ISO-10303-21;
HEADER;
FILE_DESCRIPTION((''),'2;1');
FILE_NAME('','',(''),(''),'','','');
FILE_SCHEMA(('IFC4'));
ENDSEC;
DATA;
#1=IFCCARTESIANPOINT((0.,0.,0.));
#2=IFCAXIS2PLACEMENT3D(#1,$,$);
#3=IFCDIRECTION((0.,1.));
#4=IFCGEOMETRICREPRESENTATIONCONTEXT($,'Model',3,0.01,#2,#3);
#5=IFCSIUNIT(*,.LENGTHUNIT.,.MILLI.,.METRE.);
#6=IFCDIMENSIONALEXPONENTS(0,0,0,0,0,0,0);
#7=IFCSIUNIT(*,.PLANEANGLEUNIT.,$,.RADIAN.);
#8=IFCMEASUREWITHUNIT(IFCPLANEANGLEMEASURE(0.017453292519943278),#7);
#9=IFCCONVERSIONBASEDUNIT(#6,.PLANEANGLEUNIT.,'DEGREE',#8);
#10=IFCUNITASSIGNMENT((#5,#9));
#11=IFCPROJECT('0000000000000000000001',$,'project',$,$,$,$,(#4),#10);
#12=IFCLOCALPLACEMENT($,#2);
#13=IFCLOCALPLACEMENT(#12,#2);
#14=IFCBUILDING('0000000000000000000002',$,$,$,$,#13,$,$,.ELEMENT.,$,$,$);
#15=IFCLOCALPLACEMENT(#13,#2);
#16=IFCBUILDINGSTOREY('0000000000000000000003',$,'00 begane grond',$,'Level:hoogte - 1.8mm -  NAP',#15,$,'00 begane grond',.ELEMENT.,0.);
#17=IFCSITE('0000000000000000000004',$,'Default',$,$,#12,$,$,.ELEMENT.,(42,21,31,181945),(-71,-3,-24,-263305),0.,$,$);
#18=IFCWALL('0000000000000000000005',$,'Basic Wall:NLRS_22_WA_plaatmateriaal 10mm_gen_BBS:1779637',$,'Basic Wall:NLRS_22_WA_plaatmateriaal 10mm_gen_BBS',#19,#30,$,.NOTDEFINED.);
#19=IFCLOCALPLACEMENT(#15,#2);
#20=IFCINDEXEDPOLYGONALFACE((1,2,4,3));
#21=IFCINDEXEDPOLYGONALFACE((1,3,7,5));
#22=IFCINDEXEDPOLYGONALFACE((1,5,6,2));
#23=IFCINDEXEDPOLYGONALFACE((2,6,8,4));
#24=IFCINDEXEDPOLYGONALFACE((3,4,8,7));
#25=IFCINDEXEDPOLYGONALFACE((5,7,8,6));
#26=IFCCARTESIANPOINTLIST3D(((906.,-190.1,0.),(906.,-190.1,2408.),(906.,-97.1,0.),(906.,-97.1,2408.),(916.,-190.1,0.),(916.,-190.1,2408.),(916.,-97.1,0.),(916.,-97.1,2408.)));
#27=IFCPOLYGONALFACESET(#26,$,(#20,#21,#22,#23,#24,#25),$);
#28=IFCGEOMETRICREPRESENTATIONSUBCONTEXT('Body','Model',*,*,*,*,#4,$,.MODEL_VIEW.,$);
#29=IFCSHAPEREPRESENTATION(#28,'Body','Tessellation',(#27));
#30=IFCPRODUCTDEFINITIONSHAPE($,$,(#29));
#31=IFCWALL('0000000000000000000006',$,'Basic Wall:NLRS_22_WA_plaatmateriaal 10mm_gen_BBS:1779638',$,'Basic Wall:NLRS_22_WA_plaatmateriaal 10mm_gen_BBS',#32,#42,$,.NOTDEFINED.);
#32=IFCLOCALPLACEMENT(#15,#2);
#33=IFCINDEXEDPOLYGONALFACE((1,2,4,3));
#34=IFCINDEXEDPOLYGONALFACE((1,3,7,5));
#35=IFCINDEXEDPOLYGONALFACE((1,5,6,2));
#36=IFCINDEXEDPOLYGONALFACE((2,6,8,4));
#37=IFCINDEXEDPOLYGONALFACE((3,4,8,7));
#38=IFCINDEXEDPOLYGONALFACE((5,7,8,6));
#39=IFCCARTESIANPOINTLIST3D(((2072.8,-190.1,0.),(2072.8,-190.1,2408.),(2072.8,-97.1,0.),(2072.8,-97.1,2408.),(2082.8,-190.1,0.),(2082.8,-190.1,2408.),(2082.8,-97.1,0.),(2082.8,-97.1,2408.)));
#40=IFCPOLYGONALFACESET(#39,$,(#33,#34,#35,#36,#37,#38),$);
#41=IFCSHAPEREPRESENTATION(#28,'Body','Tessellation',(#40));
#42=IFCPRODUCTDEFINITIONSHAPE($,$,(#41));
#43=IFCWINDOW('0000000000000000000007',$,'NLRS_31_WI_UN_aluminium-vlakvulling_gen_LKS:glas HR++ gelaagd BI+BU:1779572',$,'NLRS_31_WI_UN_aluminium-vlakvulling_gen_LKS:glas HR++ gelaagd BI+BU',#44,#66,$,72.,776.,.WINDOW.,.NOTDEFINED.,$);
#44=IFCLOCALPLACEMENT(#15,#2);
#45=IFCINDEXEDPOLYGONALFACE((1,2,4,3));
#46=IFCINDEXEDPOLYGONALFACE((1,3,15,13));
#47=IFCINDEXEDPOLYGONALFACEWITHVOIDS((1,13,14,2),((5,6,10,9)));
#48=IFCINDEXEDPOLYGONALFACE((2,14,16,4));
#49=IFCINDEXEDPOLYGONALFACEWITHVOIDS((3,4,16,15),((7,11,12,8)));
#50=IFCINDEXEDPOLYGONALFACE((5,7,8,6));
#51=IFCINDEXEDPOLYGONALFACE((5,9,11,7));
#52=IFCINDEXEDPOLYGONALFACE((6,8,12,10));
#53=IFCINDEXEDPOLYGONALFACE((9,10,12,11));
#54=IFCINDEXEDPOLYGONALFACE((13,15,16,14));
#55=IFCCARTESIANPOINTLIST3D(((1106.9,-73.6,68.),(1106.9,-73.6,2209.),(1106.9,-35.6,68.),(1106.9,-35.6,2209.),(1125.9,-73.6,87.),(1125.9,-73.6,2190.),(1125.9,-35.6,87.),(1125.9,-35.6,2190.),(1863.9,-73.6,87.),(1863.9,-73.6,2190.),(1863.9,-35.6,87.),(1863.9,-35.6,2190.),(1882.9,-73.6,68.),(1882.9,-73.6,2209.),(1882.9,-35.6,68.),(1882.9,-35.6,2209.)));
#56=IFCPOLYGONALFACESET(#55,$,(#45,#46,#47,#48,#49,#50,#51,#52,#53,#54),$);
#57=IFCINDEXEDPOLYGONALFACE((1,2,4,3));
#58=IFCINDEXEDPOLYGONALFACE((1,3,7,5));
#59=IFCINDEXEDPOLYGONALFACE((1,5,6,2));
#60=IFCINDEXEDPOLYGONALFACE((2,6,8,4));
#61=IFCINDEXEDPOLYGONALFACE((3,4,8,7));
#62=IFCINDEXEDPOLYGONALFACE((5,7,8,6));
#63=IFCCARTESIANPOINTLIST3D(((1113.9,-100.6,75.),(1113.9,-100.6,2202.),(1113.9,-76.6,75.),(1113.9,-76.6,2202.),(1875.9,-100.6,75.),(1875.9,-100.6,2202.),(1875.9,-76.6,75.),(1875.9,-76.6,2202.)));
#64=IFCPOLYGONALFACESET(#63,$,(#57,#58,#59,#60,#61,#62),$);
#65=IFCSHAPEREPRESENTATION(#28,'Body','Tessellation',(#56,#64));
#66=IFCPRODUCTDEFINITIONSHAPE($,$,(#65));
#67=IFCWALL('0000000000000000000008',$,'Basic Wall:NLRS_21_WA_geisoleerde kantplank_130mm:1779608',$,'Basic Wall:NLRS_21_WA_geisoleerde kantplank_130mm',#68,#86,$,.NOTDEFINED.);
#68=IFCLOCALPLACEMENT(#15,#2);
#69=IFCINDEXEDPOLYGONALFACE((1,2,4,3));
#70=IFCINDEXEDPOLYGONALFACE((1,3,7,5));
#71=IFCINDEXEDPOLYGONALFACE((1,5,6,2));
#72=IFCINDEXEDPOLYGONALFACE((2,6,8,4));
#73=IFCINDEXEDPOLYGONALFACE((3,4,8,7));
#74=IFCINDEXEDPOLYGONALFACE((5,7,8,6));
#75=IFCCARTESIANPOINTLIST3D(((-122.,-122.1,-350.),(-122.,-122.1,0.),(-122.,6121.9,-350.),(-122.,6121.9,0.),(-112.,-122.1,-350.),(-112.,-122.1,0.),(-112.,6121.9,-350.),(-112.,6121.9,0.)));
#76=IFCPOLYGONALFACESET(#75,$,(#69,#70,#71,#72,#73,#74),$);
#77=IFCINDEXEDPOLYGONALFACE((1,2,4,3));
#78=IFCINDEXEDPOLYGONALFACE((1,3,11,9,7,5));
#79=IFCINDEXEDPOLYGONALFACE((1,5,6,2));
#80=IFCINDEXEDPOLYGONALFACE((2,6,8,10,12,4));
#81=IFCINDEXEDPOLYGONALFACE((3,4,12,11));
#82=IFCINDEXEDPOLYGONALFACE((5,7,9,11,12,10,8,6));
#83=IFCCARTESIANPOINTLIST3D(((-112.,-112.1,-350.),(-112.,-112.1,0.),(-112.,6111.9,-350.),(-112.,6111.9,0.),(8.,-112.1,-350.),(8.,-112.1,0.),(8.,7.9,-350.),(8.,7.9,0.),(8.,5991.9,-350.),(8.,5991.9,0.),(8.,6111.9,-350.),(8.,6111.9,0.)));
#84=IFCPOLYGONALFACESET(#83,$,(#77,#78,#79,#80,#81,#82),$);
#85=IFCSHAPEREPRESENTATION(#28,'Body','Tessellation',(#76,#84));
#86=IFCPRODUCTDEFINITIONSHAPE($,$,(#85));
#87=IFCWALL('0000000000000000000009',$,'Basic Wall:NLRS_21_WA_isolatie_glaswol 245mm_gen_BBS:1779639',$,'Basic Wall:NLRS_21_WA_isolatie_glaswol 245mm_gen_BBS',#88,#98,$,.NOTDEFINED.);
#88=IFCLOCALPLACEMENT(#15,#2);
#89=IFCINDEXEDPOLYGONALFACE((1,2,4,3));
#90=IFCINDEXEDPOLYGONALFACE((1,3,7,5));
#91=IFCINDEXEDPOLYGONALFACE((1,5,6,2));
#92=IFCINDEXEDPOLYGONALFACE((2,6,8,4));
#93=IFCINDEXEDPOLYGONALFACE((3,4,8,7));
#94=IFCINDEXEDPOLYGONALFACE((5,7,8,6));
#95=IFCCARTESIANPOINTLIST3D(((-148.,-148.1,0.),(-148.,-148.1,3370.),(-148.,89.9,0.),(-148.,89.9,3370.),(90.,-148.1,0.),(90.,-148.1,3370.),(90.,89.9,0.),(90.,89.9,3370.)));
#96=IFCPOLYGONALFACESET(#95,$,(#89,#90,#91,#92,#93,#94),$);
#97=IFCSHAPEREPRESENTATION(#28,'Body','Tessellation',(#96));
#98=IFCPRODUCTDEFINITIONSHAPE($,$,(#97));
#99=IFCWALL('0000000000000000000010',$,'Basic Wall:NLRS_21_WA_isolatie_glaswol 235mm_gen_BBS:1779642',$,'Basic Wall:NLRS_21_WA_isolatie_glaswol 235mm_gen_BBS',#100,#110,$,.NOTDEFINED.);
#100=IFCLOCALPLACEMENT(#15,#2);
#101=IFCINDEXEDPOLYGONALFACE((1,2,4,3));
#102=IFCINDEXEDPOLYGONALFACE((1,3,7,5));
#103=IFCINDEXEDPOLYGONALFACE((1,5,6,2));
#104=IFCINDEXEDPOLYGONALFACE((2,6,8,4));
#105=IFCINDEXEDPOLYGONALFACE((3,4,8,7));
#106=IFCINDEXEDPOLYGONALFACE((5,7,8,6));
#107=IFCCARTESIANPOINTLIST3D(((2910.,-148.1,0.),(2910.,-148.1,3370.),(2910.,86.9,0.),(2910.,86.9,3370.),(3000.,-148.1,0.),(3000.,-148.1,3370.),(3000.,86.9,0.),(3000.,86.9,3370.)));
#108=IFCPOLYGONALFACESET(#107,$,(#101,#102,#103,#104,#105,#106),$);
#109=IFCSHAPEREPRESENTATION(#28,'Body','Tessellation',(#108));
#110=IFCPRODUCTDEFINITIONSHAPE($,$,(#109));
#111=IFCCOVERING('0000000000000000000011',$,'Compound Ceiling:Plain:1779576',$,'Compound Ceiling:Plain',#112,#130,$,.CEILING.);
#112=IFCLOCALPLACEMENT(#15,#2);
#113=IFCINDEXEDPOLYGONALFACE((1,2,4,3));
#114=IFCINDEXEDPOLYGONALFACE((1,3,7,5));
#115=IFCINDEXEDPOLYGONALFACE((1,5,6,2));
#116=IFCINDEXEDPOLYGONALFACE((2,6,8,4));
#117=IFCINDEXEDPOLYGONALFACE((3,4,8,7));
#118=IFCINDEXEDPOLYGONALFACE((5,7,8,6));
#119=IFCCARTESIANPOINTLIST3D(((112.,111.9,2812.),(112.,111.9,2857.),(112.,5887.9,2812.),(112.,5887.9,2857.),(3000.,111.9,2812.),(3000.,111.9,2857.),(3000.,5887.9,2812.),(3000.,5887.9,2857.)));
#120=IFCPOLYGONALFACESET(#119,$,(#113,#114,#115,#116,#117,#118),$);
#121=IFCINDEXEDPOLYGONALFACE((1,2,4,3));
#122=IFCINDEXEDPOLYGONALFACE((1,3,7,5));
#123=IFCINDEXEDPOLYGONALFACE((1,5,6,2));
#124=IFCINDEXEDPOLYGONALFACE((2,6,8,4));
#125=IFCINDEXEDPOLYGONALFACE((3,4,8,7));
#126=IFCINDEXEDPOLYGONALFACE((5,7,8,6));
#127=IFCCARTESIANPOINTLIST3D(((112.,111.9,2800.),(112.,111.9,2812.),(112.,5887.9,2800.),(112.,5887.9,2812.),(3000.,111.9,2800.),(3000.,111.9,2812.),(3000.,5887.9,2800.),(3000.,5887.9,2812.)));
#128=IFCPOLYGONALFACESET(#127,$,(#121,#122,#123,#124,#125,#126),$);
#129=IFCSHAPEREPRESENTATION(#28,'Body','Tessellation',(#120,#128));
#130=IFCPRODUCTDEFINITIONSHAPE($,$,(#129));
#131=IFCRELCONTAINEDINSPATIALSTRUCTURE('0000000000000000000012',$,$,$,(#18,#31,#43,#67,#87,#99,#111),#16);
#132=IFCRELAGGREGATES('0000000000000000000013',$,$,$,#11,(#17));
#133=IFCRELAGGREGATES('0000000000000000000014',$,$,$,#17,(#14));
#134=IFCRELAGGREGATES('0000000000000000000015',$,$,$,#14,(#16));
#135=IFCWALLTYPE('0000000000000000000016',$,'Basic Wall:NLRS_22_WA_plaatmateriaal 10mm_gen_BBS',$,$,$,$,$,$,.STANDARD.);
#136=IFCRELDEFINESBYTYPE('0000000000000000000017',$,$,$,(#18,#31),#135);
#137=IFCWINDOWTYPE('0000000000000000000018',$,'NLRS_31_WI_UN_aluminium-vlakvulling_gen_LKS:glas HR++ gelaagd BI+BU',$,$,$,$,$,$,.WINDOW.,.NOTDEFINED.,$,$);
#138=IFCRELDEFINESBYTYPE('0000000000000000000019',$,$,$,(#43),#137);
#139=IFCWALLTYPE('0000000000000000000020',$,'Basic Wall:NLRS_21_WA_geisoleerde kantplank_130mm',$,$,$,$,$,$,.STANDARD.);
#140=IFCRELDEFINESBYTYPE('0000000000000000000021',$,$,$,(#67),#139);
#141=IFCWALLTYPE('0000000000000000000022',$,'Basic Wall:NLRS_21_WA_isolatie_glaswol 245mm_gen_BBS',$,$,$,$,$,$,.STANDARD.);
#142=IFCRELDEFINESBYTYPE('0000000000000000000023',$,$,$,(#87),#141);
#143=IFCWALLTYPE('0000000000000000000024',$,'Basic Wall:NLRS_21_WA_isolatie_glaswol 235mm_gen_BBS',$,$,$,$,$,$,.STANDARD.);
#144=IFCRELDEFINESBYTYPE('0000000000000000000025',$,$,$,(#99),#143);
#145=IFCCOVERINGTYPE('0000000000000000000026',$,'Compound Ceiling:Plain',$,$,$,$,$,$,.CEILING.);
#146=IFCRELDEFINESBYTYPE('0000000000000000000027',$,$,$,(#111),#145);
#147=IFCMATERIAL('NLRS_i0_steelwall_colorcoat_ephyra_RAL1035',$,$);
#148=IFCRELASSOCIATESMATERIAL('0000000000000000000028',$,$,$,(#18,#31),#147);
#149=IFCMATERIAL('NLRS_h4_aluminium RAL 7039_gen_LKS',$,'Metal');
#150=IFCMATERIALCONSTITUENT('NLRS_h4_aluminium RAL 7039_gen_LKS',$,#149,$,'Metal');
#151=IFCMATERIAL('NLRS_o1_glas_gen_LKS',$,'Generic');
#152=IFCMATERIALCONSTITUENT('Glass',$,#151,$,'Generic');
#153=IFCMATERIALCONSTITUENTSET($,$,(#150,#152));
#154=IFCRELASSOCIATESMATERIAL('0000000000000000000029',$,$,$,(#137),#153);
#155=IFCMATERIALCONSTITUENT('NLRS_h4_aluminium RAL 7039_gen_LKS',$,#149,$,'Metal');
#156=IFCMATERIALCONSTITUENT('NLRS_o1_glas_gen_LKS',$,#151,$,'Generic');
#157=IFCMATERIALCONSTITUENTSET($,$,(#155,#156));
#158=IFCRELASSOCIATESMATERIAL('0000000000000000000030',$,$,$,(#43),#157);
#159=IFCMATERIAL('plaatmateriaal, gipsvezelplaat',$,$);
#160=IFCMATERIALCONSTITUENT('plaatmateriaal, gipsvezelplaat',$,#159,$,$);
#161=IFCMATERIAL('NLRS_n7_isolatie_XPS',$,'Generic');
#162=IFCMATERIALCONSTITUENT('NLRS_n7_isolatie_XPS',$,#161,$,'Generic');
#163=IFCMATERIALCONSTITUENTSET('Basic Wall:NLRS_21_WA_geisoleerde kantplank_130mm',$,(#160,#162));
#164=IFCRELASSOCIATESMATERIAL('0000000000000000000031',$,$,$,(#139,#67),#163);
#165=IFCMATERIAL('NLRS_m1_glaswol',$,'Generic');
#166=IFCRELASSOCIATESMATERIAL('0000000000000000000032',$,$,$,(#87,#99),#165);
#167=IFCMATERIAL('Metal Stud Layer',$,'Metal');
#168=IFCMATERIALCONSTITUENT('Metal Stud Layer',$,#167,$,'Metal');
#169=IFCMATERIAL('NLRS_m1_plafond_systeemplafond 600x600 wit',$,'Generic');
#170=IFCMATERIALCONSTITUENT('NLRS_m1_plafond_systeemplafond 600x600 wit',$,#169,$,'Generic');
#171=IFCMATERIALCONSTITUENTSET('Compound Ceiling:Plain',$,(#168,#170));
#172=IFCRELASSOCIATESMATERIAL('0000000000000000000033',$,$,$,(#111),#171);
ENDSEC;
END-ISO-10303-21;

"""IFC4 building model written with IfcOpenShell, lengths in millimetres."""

from ifc_helpers import new_model, entity, si_unit, converted_unit, direction, frame, origin, place, context, subcontext, project, spatial, indexed_curve, outline, extrude, source, transform, mapped, material, constituent, constituent_set, type_object, type_shapes, element, save


model = new_model("IFC4")

# Units and contexts
model_context = context("Model", 3, precision=0.01, world=origin(), true_north=direction((0.0, 1.0)))
body_context = subcontext(model_context, "Body", "Model", "MODEL_VIEW")
ifc_project = project(units=[si_unit("LENGTHUNIT", "METRE", prefix="MILLI"), converted_unit("PLANEANGLEUNIT", "DEGREE", entity("IfcPlaneAngleMeasure", 0.017453292519943278), si_unit("PLANEANGLEUNIT", "RADIAN"), dimensions=[0, 0, 0, 0, 0, 0, 0])], contexts=[model_context])

# Site, building, storey
site_placement = place(None, origin())
site = spatial("IfcSite", under=ifc_project, at=site_placement, Name="Default", CompositionType="ELEMENT", RefLatitude=(42, 21, 31, 181945), RefLongitude=(-71, -3, -24, -263305), RefElevation=0.0)
building_placement = place(site_placement, origin())
building = spatial("IfcBuilding", under=site, at=building_placement, CompositionType="ELEMENT")
storey_placement = place(building_placement, origin())
storey = spatial("IfcBuildingStorey", under=building, at=storey_placement, Name="00 begane grond", ObjectType="Level:hoogte - 1.8mm -  NAP", LongName="00 begane grond", CompositionType="ELEMENT", Elevation=0.0)

# Walls
ifc_material_1 = material(Name="NLRS_i0_steelwall_colorcoat_ephyra_RAL1035")
wall_type_1 = type_object("IfcWallType", Name="Basic Wall:NLRS_22_WA_plaatmateriaal 10mm_gen_BBS", PredefinedType="STANDARD")
wall_1_placement = place(storey_placement, frame((911.0, -190.1, 0.0), z_axis=(0.0, 0.0, 1.0), x_axis=(0.0, 1.0, 0.0)))
element("IfcWall", 1, at=wall_1_placement, inside=storey, type_object=wall_type_1, material=ifc_material_1, Name="Basic Wall:NLRS_22_WA_plaatmateriaal 10mm_gen_BBS:1779637", ObjectType="Basic Wall:NLRS_22_WA_plaatmateriaal 10mm_gen_BBS", PredefinedType="NOTDEFINED", context=body_context, shape_type="SweptSolid", body=[
    extrude(outline(indexed_curve([(93.0, 5.0), (0.0, 5.0), (0.0, -5.0), (93.0, -5.0), (93.0, 5.0)], self_intersect=False)), origin(), (0.0, 0.0, 1.0), 2408.0),
])
wall_2_placement = place(storey_placement, frame((2077.8, -190.1, 0.0), z_axis=(0.0, 0.0, 1.0), x_axis=(0.0, 1.0, 0.0)))
element("IfcWall", 2, at=wall_2_placement, inside=storey, type_object=wall_type_1, material=ifc_material_1, Name="Basic Wall:NLRS_22_WA_plaatmateriaal 10mm_gen_BBS:1779638", ObjectType="Basic Wall:NLRS_22_WA_plaatmateriaal 10mm_gen_BBS", PredefinedType="NOTDEFINED", context=body_context, shape_type="SweptSolid", body=[
    extrude(outline(indexed_curve([(93.0, 5.0), (0.0, 5.0), (0.0, -5.0), (93.0, -5.0), (93.0, 5.0)], self_intersect=False)), origin(), (0.0, 0.0, 1.0), 2408.0),
])

# Window
ifc_material_2 = material(Name="NLRS_h4_aluminium RAL 7039_gen_LKS", Category="Metal")
ifc_constituent_1 = constituent(ifc_material_2, Name="NLRS_h4_aluminium RAL 7039_gen_LKS", Category="Metal")
ifc_material_3 = material(Name="NLRS_o1_glas_gen_LKS", Category="Generic")
ifc_constituent_2 = constituent(ifc_material_3, Name="NLRS_o1_glas_gen_LKS", Category="Generic")
ifc_constituent_set_1 = constituent_set(constituents=[ifc_constituent_1, ifc_constituent_2])
ifc_constituent_3 = constituent(ifc_material_2, Name="NLRS_h4_aluminium RAL 7039_gen_LKS", Category="Metal")
ifc_constituent_4 = constituent(ifc_material_3, Name="Glass", Category="Generic")
ifc_constituent_set_2 = constituent_set(constituents=[ifc_constituent_3, ifc_constituent_4])
window_type = type_object("IfcWindowType", Name="NLRS_31_WI_UN_aluminium-vlakvulling_gen_LKS:glas HR++ gelaagd BI+BU", PartitioningType="NOTDEFINED", PredefinedType="WINDOW", material=ifc_constituent_set_2)
shared_shape_1 = source(origin(), body_context, "Body", "SweptSolid", [
    extrude(outline(indexed_curve([(-1070.5, -388.0), (1070.5, -388.0), (1070.5, 388.0), (-1070.5, 388.0), (-1070.5, -388.0)], self_intersect=False), holes=[indexed_curve([(1051.5, -369.0), (-1051.5, -369.0), (-1051.5, 369.0), (1051.5, 369.0), (1051.5, -369.0)], self_intersect=False)]), frame((0.0, 34.0, 1070.5), z_axis=(0.0, 1.0, 0.0), x_axis=(0.0, 0.0, -1.0)), (0.0, 0.0, 1.0), 38.0),
    extrude(outline(indexed_curve([(-12.0, -381.0), (12.0, -381.0), (12.0, 381.0), (-12.0, 381.0), (-12.0, -381.0)], self_intersect=False)), frame((0.0, 19.0, 7.0), z_axis=(0.0, 0.0, 1.0), x_axis=(0.0, -1.0, 0.0)), (0.0, 0.0, 1.0), 2127.0),
])
type_shapes(window_type, [shared_shape_1])
window_placement = place(storey_placement, frame((1494.9, -107.6, 68.0)))
element("IfcWindow", 3, at=window_placement, inside=storey, type_object=window_type, material=ifc_constituent_set_1, Name="NLRS_31_WI_UN_aluminium-vlakvulling_gen_LKS:glas HR++ gelaagd BI+BU:1779572", ObjectType="NLRS_31_WI_UN_aluminium-vlakvulling_gen_LKS:glas HR++ gelaagd BI+BU", OverallHeight=72.0, OverallWidth=776.0, PartitioningType="NOTDEFINED", PredefinedType="WINDOW", context=body_context, shape_type="MappedRepresentation", body=[
    mapped(shared_shape_1, transform((0.0, 0.0, 0.0), scale=1.0)),
])

# Wall
ifc_material_4 = material(Name="plaatmateriaal, gipsvezelplaat")
ifc_constituent_5 = constituent(ifc_material_4, Name="plaatmateriaal, gipsvezelplaat")
ifc_material_5 = material(Name="NLRS_n7_isolatie_XPS", Category="Generic")
ifc_constituent_6 = constituent(ifc_material_5, Name="NLRS_n7_isolatie_XPS", Category="Generic")
ifc_constituent_set_3 = constituent_set(constituents=[ifc_constituent_5, ifc_constituent_6], Name="Basic Wall:NLRS_21_WA_geisoleerde kantplank_130mm")
wall_type_2 = type_object("IfcWallType", Name="Basic Wall:NLRS_21_WA_geisoleerde kantplank_130mm", PredefinedType="STANDARD", material=ifc_constituent_set_3)
wall_3_placement = place(storey_placement, frame((-57.0, -122.1, -350.0), z_axis=(0.0, 0.0, 1.0), x_axis=(0.0, 1.0, 0.0)))
element("IfcWall", 4, at=wall_3_placement, inside=storey, type_object=wall_type_2, material=ifc_constituent_set_3, Name="Basic Wall:NLRS_21_WA_geisoleerde kantplank_130mm:1779608", ObjectType="Basic Wall:NLRS_21_WA_geisoleerde kantplank_130mm", PredefinedType="NOTDEFINED", context=body_context, shape_type="SweptSolid", body=[
    extrude(outline(indexed_curve([(-5.0, -3122.0), (5.0, -3122.0), (5.0, 3122.0), (-5.0, 3122.0), (-5.0, -3122.0)], self_intersect=False)), frame((3122.0, 60.0, 0.0), z_axis=(0.0, 0.0, 1.0), x_axis=(0.0, -1.0, 0.0)), (0.0, 0.0, 1.0), 350.0),
    extrude(outline(indexed_curve([(-2992.0, -40.0), (2992.0, -40.0), (3112.0, -40.0), (3112.0, 80.0), (-3112.0, 80.0), (-3112.0, -40.0), (-2992.0, -40.0)], self_intersect=False)), frame((3122.0, -25.0, 0.0)), (0.0, 0.0, 1.0), 350.0),
])

# Walls
ifc_material_6 = material(Name="NLRS_m1_glaswol", Category="Generic")
wall_type_3 = type_object("IfcWallType", Name="Basic Wall:NLRS_21_WA_isolatie_glaswol 245mm_gen_BBS", PredefinedType="STANDARD")
wall_4_placement = place(storey_placement, frame((-29.0, -148.1, 0.0), z_axis=(0.0, 0.0, 1.0), x_axis=(0.0, 1.0, 0.0)))
element("IfcWall", 5, at=wall_4_placement, inside=storey, type_object=wall_type_3, material=ifc_material_6, Name="Basic Wall:NLRS_21_WA_isolatie_glaswol 245mm_gen_BBS:1779639", ObjectType="Basic Wall:NLRS_21_WA_isolatie_glaswol 245mm_gen_BBS", PredefinedType="NOTDEFINED", context=body_context, shape_type="SweptSolid", body=[
    extrude(outline(indexed_curve([(238.0, 119.0), (0.0, 119.0), (0.0, -119.0), (238.0, -119.0), (238.0, 119.0)], self_intersect=False)), origin(), (0.0, 0.0, 1.0), 3370.0),
])
wall_type_4 = type_object("IfcWallType", Name="Basic Wall:NLRS_21_WA_isolatie_glaswol 235mm_gen_BBS", PredefinedType="STANDARD")
wall_5_placement = place(storey_placement, frame((2910.0, -30.6, 0.0)))
element("IfcWall", 6, at=wall_5_placement, inside=storey, type_object=wall_type_4, material=ifc_material_6, Name="Basic Wall:NLRS_21_WA_isolatie_glaswol 235mm_gen_BBS:1779642", ObjectType="Basic Wall:NLRS_21_WA_isolatie_glaswol 235mm_gen_BBS", PredefinedType="NOTDEFINED", context=body_context, shape_type="SweptSolid", body=[
    extrude(outline(indexed_curve([(90.0, 117.5), (0.0, 117.5), (0.0, -117.5), (90.0, -117.5), (90.0, 117.5)], self_intersect=False)), origin(), (0.0, 0.0, 1.0), 3370.0),
])

# Covering
ifc_material_7 = material(Name="Metal Stud Layer", Category="Metal")
ifc_constituent_7 = constituent(ifc_material_7, Name="Metal Stud Layer", Category="Metal")
ifc_material_8 = material(Name="NLRS_m1_plafond_systeemplafond 600x600 wit", Category="Generic")
ifc_constituent_8 = constituent(ifc_material_8, Name="NLRS_m1_plafond_systeemplafond 600x600 wit", Category="Generic")
ifc_constituent_set_4 = constituent_set(constituents=[ifc_constituent_7, ifc_constituent_8], Name="Compound Ceiling:Plain")
covering_type = type_object("IfcCoveringType", Name="Compound Ceiling:Plain", PredefinedType="CEILING")
covering_placement = place(storey_placement, frame((112.0, 111.9, 2800.0)))
element("IfcCovering", 7, at=covering_placement, inside=storey, type_object=covering_type, material=ifc_constituent_set_4, Name="Compound Ceiling:Plain:1779576", ObjectType="Compound Ceiling:Plain", PredefinedType="CEILING", context=body_context, shape_type="SweptSolid", body=[
    extrude(outline(indexed_curve([(-2888.0, -1444.0), (2888.0, -1444.0), (2888.0, 1444.0), (-2888.0, 1444.0), (-2888.0, -1444.0)], self_intersect=False)), frame((1444.0, 2888.0, 12.0), z_axis=(0.0, 0.0, 1.0), x_axis=(0.0, -1.0, 0.0)), (0.0, 0.0, 1.0), 45.0),
    extrude(outline(indexed_curve([(-1444.0, -2888.0), (1444.0, -2888.0), (1444.0, 2888.0), (-1444.0, 2888.0), (-1444.0, -2888.0)], self_intersect=False)), frame((1444.0, 2888.0, 0.0), z_axis=(0.0, 0.0, 1.0), x_axis=(-1.0, 0.0, 0.0)), (0.0, 0.0, 1.0), 12.0),
])

save(model, "model.ifc")
